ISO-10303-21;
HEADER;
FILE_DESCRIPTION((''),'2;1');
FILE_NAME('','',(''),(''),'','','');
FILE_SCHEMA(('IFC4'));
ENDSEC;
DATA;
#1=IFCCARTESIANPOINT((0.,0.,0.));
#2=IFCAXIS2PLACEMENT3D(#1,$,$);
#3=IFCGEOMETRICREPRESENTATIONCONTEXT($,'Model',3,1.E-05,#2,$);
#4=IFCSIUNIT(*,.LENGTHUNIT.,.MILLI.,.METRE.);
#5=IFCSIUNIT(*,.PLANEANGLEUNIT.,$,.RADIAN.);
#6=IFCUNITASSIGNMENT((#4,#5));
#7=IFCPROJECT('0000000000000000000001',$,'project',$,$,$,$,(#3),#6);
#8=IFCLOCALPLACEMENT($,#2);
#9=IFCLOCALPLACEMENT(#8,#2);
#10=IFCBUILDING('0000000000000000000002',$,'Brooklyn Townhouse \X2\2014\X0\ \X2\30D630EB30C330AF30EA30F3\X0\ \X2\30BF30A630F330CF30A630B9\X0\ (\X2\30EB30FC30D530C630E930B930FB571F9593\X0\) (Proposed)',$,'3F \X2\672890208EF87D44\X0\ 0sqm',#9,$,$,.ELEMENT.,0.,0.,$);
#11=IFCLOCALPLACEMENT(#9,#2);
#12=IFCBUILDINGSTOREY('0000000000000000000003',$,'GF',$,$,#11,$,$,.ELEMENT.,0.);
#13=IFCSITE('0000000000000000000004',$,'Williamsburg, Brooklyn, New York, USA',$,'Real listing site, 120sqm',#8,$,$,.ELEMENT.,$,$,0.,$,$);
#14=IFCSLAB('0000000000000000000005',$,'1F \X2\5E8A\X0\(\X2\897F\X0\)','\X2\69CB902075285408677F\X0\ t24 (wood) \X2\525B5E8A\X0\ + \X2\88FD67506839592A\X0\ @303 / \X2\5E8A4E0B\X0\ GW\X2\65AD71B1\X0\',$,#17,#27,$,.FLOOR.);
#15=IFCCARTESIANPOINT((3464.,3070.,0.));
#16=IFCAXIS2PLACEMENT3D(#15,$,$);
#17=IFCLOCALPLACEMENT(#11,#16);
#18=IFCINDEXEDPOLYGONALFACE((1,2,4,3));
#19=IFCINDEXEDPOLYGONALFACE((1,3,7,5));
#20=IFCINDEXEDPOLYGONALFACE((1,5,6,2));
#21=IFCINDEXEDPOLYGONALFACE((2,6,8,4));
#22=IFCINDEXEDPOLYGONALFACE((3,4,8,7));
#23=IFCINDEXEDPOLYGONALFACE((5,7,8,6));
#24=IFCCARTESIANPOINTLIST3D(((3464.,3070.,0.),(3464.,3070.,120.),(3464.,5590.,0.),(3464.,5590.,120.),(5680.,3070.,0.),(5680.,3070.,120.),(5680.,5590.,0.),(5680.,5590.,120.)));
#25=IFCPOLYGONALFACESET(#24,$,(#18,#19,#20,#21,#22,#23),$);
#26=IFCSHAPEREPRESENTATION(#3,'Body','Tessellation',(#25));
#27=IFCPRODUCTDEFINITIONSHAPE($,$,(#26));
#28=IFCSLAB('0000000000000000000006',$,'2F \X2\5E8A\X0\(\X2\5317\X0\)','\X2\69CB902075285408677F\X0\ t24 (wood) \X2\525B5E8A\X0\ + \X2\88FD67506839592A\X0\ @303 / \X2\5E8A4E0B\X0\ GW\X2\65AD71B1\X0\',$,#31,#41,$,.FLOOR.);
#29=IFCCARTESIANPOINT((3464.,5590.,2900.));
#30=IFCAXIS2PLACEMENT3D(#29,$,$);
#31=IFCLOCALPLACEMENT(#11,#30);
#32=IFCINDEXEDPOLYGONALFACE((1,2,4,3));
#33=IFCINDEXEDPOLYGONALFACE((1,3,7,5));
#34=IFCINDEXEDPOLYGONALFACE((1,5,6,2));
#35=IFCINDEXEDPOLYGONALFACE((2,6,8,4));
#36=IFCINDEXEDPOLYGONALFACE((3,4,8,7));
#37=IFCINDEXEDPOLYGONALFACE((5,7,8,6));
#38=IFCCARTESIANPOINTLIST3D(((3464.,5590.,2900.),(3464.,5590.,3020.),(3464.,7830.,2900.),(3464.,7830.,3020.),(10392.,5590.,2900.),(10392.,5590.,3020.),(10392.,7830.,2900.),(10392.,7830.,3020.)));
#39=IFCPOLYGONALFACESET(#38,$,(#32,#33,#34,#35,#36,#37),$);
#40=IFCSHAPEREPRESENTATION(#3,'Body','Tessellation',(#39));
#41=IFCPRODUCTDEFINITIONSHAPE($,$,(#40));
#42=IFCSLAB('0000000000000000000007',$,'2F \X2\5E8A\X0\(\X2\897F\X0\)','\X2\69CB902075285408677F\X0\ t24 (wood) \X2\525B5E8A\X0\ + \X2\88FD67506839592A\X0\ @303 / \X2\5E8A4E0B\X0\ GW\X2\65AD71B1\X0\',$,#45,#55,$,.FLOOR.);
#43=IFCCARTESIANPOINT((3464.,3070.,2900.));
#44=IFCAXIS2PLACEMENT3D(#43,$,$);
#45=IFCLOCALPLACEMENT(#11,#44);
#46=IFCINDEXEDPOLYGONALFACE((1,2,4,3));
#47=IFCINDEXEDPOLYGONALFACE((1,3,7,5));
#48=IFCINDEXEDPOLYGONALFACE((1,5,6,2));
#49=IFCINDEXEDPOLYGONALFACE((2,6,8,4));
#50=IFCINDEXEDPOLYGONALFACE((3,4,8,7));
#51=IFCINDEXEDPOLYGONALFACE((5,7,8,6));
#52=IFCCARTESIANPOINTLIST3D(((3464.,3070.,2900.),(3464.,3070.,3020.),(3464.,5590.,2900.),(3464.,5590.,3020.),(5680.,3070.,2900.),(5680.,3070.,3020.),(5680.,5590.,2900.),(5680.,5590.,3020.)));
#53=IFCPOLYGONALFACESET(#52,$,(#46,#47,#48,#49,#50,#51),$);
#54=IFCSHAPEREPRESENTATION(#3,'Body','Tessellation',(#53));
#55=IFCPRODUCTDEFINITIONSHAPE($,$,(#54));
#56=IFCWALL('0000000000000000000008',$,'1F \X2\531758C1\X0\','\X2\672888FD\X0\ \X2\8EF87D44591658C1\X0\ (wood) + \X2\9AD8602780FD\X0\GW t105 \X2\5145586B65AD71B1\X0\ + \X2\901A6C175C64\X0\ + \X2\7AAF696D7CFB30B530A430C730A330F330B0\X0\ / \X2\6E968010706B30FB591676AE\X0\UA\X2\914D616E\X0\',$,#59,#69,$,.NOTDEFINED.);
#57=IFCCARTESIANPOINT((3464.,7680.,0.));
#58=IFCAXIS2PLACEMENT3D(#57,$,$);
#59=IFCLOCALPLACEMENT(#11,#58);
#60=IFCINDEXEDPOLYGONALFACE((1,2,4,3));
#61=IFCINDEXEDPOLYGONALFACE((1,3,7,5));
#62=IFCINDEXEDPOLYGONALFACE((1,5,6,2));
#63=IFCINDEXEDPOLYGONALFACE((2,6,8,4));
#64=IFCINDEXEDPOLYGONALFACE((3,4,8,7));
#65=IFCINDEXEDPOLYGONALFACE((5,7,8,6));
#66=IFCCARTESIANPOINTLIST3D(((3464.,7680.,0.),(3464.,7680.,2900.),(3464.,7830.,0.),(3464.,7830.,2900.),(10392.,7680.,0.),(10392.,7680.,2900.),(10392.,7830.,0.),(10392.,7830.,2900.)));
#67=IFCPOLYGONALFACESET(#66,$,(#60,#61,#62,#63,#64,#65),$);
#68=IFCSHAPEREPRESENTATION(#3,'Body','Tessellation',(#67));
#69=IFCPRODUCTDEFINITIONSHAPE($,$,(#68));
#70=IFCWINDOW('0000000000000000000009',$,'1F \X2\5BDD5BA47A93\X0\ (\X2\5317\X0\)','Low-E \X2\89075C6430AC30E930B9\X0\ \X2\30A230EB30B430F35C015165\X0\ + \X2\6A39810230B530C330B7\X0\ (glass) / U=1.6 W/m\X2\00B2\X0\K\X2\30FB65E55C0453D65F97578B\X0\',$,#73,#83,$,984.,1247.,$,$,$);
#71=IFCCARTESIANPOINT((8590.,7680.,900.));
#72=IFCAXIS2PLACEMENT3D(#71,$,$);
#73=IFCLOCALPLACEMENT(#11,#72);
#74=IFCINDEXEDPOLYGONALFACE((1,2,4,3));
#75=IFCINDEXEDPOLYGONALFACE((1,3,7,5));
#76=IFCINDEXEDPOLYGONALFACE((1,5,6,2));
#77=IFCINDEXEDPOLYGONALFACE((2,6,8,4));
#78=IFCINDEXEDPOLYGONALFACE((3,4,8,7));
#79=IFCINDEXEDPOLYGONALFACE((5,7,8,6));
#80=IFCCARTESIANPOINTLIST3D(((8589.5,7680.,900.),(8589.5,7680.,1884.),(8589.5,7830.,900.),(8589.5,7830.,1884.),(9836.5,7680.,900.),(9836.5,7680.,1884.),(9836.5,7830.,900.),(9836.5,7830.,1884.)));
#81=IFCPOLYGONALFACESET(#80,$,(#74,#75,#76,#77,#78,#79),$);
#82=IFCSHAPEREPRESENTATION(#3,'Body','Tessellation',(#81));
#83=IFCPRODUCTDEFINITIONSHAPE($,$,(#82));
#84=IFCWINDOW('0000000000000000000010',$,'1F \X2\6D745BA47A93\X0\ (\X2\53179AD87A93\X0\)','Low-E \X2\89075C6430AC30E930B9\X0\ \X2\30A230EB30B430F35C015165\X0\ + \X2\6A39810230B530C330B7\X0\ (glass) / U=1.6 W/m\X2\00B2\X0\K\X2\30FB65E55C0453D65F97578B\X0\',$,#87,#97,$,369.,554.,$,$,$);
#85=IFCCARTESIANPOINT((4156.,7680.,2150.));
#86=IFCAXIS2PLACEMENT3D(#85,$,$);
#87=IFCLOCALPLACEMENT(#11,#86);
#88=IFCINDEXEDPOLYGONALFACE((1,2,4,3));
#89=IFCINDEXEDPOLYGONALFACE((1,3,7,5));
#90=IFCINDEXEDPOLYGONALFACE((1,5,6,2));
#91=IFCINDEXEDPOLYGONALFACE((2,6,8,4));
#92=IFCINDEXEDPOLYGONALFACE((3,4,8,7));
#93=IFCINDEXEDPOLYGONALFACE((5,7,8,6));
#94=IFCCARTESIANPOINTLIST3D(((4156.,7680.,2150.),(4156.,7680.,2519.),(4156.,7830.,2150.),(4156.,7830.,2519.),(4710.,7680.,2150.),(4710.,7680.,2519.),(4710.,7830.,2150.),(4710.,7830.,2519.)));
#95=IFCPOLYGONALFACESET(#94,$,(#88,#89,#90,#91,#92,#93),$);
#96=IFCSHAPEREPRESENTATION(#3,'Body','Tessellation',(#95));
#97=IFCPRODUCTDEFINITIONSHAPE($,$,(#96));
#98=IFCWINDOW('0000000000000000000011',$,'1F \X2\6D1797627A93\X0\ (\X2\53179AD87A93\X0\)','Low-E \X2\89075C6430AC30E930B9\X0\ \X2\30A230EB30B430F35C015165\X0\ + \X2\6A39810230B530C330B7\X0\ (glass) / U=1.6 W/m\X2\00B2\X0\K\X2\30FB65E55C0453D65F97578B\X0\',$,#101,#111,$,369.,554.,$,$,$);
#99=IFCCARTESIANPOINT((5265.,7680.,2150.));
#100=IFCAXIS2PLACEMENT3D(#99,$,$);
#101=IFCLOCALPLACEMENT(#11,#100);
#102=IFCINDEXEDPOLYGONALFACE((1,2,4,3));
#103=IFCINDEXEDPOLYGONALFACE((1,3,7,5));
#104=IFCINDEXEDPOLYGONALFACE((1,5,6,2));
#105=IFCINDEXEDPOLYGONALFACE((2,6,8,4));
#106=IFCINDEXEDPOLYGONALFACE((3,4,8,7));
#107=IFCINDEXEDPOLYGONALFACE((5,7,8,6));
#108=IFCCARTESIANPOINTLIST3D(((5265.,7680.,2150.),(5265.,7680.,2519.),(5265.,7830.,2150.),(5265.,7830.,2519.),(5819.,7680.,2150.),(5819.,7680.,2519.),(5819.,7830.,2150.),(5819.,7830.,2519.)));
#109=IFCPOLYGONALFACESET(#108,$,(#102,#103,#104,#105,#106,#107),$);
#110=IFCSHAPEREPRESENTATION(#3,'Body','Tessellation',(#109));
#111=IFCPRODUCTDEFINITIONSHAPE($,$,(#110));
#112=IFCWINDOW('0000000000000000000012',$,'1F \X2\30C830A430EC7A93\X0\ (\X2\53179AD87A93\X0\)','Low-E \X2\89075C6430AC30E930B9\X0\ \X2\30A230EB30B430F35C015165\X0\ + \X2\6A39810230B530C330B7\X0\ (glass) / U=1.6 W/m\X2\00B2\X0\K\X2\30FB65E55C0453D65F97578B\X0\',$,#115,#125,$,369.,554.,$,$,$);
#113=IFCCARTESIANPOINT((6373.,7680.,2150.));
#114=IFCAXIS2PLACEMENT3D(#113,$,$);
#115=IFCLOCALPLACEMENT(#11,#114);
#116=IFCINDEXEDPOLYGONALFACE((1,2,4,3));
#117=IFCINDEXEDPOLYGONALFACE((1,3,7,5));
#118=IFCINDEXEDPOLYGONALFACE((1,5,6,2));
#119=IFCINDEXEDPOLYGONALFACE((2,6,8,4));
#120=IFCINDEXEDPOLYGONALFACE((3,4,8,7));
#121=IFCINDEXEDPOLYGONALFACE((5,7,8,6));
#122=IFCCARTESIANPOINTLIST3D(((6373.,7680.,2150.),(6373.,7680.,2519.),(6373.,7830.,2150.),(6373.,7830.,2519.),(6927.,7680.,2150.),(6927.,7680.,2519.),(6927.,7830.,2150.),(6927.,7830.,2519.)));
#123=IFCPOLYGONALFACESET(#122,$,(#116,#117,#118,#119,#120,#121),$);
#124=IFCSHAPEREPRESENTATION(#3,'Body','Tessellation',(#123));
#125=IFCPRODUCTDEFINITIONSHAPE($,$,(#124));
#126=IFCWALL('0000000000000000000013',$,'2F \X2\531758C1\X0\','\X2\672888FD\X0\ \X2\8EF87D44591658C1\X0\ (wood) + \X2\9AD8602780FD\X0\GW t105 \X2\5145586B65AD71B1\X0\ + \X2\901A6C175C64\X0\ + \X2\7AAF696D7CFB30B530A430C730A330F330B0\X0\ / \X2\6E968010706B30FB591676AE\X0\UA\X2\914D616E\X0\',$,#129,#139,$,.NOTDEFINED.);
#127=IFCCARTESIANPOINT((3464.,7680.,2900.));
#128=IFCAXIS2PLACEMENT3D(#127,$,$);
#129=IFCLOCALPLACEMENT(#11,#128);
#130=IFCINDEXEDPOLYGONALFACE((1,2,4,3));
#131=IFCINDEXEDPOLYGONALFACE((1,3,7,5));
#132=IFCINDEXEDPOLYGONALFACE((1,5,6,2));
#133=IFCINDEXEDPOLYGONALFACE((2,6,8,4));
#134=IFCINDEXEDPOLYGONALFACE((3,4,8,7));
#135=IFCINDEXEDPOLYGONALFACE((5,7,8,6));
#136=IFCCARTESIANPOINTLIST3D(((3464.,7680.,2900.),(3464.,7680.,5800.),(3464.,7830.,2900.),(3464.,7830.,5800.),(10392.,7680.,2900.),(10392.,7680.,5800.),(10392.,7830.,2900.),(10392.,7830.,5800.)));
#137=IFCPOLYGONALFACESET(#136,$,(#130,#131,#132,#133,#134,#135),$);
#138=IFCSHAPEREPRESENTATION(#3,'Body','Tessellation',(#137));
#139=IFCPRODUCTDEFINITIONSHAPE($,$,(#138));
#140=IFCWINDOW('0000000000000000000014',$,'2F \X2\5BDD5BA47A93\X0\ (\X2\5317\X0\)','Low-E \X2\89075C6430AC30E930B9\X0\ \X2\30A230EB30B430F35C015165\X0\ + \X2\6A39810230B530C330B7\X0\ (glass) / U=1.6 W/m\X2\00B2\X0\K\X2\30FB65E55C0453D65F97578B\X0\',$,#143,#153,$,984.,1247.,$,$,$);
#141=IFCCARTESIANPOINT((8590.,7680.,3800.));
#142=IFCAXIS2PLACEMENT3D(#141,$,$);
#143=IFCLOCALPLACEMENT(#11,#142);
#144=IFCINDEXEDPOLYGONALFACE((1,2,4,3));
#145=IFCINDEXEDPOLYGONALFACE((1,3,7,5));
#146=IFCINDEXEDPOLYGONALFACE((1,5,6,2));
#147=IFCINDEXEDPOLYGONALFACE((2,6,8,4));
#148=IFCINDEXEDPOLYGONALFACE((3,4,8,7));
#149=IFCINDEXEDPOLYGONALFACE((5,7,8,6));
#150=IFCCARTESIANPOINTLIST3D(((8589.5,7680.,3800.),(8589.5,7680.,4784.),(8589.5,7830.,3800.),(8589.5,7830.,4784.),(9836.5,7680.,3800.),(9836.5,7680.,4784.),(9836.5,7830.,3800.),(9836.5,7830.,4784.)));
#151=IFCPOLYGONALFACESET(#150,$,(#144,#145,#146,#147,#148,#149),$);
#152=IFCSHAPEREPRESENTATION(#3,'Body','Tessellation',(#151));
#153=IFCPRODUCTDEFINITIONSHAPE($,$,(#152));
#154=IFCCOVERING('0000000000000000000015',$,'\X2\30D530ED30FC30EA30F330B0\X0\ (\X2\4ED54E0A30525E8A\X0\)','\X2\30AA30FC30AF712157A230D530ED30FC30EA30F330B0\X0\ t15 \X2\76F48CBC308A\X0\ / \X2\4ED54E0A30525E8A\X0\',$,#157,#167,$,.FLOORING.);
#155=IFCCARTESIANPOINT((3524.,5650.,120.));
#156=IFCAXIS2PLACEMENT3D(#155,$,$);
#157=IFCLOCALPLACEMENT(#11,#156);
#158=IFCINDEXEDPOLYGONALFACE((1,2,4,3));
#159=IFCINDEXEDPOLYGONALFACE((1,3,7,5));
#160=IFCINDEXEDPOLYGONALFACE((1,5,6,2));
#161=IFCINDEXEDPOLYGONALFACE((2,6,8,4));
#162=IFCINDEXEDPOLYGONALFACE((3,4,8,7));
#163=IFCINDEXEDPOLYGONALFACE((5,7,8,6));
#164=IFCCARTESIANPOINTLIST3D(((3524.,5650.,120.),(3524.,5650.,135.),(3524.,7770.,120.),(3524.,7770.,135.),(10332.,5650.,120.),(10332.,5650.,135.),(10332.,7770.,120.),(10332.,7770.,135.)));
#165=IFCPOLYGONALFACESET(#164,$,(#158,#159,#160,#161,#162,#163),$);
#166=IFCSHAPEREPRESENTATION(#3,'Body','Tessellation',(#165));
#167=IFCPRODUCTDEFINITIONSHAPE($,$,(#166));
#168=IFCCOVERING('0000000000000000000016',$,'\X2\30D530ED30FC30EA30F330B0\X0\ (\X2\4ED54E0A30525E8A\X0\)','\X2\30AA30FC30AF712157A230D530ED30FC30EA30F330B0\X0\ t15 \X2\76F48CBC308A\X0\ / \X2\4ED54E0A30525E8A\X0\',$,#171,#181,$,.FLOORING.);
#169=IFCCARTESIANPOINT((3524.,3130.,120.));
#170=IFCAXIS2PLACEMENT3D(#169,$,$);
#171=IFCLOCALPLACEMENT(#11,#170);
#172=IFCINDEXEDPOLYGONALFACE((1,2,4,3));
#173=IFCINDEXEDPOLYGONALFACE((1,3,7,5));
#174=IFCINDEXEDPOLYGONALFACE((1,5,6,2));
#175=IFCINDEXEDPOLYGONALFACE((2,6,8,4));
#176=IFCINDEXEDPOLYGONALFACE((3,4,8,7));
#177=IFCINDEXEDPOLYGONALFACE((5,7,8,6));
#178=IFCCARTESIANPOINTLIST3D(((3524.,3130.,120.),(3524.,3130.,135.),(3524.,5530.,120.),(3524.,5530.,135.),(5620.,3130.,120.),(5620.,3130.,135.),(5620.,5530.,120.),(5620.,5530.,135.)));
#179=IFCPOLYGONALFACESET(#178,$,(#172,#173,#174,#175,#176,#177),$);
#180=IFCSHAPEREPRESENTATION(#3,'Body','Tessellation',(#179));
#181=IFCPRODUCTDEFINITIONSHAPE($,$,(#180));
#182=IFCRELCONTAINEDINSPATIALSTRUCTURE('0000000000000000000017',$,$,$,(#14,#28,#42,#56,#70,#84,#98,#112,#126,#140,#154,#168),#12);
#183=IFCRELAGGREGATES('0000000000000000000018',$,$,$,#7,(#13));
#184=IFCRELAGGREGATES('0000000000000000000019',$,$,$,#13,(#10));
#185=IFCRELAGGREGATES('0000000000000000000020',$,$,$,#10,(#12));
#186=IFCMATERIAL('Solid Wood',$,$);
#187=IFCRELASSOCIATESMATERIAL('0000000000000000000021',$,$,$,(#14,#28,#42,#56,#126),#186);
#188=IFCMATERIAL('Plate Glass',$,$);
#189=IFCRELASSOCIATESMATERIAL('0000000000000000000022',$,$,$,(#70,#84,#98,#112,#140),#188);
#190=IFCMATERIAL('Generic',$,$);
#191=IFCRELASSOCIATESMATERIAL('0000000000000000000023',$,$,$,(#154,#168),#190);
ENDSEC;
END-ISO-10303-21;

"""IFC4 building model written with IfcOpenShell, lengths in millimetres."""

from ifc_helpers import new_model, si_unit, frame, frame_2d, origin, place, context, project, spatial, rectangle, extrude, material, element, fill, save


model = new_model("IFC4")

# Units and contexts
model_context = context("Model", 3, precision=1e-05, world=origin())
ifc_project = project(units=[si_unit("LENGTHUNIT", "METRE", prefix="MILLI"), si_unit("PLANEANGLEUNIT", "RADIAN")], contexts=[model_context])

# Site, building, storey
site_placement = place(None, origin())
site = spatial("IfcSite", under=ifc_project, at=site_placement, Name="Williamsburg, Brooklyn, New York, USA", ObjectType="Real listing site, 120sqm", CompositionType="ELEMENT", RefElevation=0.0)
building_placement = place(site_placement, origin())
building = spatial("IfcBuilding", under=site, at=building_placement, Name="Brooklyn Townhouse — ブルックリン タウンハウス (ルーフテラス・土間) (Proposed)", ObjectType="3F 木造軸組 0sqm", CompositionType="ELEMENT", ElevationOfRefHeight=0.0, ElevationOfTerrain=0.0)
storey_placement = place(building_placement, origin())
storey = spatial("IfcBuildingStorey", under=building, at=storey_placement, Name="GF", CompositionType="ELEMENT", Elevation=0.0)

# Slabs
ifc_material_1 = material(Name="Solid Wood")
slab_1_placement = place(storey_placement, frame((3464.0, 3070.0, 0.0)))
element("IfcSlab", 1, at=slab_1_placement, inside=storey, material=ifc_material_1, Name="1F 床(西)", Description="構造用合板 t24 (wood) 剛床 + 製材根太 @303 / 床下 GW断熱", PredefinedType="FLOOR", context=model_context, shape_type="SweptSolid", body=[
    extrude(rectangle(XDim=2216.0, YDim=2520.0, at=frame_2d((1108.0, 1260.0))), frame((3464.0, 3070.0, 0.0)), (0.0, 0.0, 1.0), 120.0),
])
slab_2_placement = place(storey_placement, frame((3464.0, 5590.0, 2900.0)))
element("IfcSlab", 2, at=slab_2_placement, inside=storey, material=ifc_material_1, Name="2F 床(北)", Description="構造用合板 t24 (wood) 剛床 + 製材根太 @303 / 床下 GW断熱", PredefinedType="FLOOR", context=model_context, shape_type="SweptSolid", body=[
    extrude(rectangle(XDim=6928.0, YDim=2240.0, at=frame_2d((3464.0, 1120.0))), frame((3464.0, 5590.0, 2900.0)), (0.0, 0.0, 1.0), 120.0),
])
slab_3_placement = place(storey_placement, frame((3464.0, 3070.0, 2900.0)))
element("IfcSlab", 3, at=slab_3_placement, inside=storey, material=ifc_material_1, Name="2F 床(西)", Description="構造用合板 t24 (wood) 剛床 + 製材根太 @303 / 床下 GW断熱", PredefinedType="FLOOR", context=model_context, shape_type="SweptSolid", body=[
    extrude(rectangle(XDim=2216.0, YDim=2520.0, at=frame_2d((1108.0, 1260.0))), frame((3464.0, 3070.0, 2900.0)), (0.0, 0.0, 1.0), 120.0),
])

# Wall, openings, windows
wall_1_placement = place(storey_placement, frame((3464.0, 7680.0, 0.0)))
wall_1 = element("IfcWall", 4, at=wall_1_placement, inside=storey, material=ifc_material_1, Name="1F 北壁", Description="木製 軸組外壁 (wood) + 高性能GW t105 充填断熱 + 通気層 + 窯業系サイディング / 準耐火・外皮UA配慮", PredefinedType="NOTDEFINED", context=model_context, shape_type="SweptSolid", body=[
    extrude(rectangle(XDim=6928.0, YDim=150.0, at=frame_2d((3464.0, 75.0))), frame((3464.0, 7680.0, 0.0)), (0.0, 0.0, 1.0), 2900.0),
])
opening_1_placement = place(storey_placement, frame((8590.0, 7680.0, 900.0)))
opening_1 = element("IfcOpeningElement", 5, at=opening_1_placement, cuts=wall_1, PredefinedType="NOTDEFINED", context=model_context, shape_type="SweptSolid", body=[
    extrude(rectangle(XDim=1247.0, YDim=150.0, at=frame_2d((623.0, 75.0))), frame((8590.0, 7680.0, 900.0)), (0.0, 0.0, 1.0), 984.0),
])
opening_2_placement = place(storey_placement, frame((4156.0, 7680.0, 2150.0)))
opening_2 = element("IfcOpeningElement", 6, at=opening_2_placement, cuts=wall_1, PredefinedType="NOTDEFINED", context=model_context, shape_type="SweptSolid", body=[
    extrude(rectangle(XDim=554.0, YDim=150.0, at=frame_2d((277.0, 75.0))), frame((4156.0, 7680.0, 2150.0)), (0.0, 0.0, 1.0), 369.0),
])
opening_3_placement = place(storey_placement, frame((5265.0, 7680.0, 2150.0)))
opening_3 = element("IfcOpeningElement", 7, at=opening_3_placement, cuts=wall_1, PredefinedType="NOTDEFINED", context=model_context, shape_type="SweptSolid", body=[
    extrude(rectangle(XDim=554.0, YDim=150.0, at=frame_2d((277.0, 75.0))), frame((5265.0, 7680.0, 2150.0)), (0.0, 0.0, 1.0), 369.0),
])
opening_4_placement = place(storey_placement, frame((6373.0, 7680.0, 2150.0)))
opening_4 = element("IfcOpeningElement", 8, at=opening_4_placement, cuts=wall_1, PredefinedType="NOTDEFINED", context=model_context, shape_type="SweptSolid", body=[
    extrude(rectangle(XDim=554.0, YDim=150.0, at=frame_2d((277.0, 75.0))), frame((6373.0, 7680.0, 2150.0)), (0.0, 0.0, 1.0), 369.0),
])
ifc_material_2 = material(Name="Plate Glass")
window_1_placement = place(storey_placement, frame((8590.0, 7680.0, 900.0)))
window_1 = element("IfcWindow", 9, at=window_1_placement, inside=storey, material=ifc_material_2, Name="1F 寝室窓 (北)", Description="Low-E 複層ガラス アルゴン封入 + 樹脂サッシ (glass) / U=1.6 W/m²K・日射取得型", OverallHeight=984.0, OverallWidth=1247.0, context=model_context, shape_type="SweptSolid", body=[
    extrude(rectangle(XDim=1247.0, YDim=150.0, at=frame_2d((623.0, 75.0))), frame((8590.0, 7680.0, 900.0)), (0.0, 0.0, 1.0), 984.0),
])
fill(opening_1, window_1)
window_2_placement = place(storey_placement, frame((4156.0, 7680.0, 2150.0)))
window_2 = element("IfcWindow", 10, at=window_2_placement, inside=storey, material=ifc_material_2, Name="1F 浴室窓 (北高窓)", Description="Low-E 複層ガラス アルゴン封入 + 樹脂サッシ (glass) / U=1.6 W/m²K・日射取得型", OverallHeight=369.0, OverallWidth=554.0, context=model_context, shape_type="SweptSolid", body=[
    extrude(rectangle(XDim=554.0, YDim=150.0, at=frame_2d((277.0, 75.0))), frame((4156.0, 7680.0, 2150.0)), (0.0, 0.0, 1.0), 369.0),
])
fill(opening_2, window_2)
window_3_placement = place(storey_placement, frame((5265.0, 7680.0, 2150.0)))
window_3 = element("IfcWindow", 11, at=window_3_placement, inside=storey, material=ifc_material_2, Name="1F 洗面窓 (北高窓)", Description="Low-E 複層ガラス アルゴン封入 + 樹脂サッシ (glass) / U=1.6 W/m²K・日射取得型", OverallHeight=369.0, OverallWidth=554.0, context=model_context, shape_type="SweptSolid", body=[
    extrude(rectangle(XDim=554.0, YDim=150.0, at=frame_2d((277.0, 75.0))), frame((5265.0, 7680.0, 2150.0)), (0.0, 0.0, 1.0), 369.0),
])
fill(opening_3, window_3)
window_4_placement = place(storey_placement, frame((6373.0, 7680.0, 2150.0)))
window_4 = element("IfcWindow", 12, at=window_4_placement, inside=storey, material=ifc_material_2, Name="1F トイレ窓 (北高窓)", Description="Low-E 複層ガラス アルゴン封入 + 樹脂サッシ (glass) / U=1.6 W/m²K・日射取得型", OverallHeight=369.0, OverallWidth=554.0, context=model_context, shape_type="SweptSolid", body=[
    extrude(rectangle(XDim=554.0, YDim=150.0, at=frame_2d((277.0, 75.0))), frame((6373.0, 7680.0, 2150.0)), (0.0, 0.0, 1.0), 369.0),
])
fill(opening_4, window_4)

# Wall, opening, window
wall_2_placement = place(storey_placement, frame((3464.0, 7680.0, 2900.0)))
wall_2 = element("IfcWall", 13, at=wall_2_placement, inside=storey, material=ifc_material_1, Name="2F 北壁", Description="木製 軸組外壁 (wood) + 高性能GW t105 充填断熱 + 通気層 + 窯業系サイディング / 準耐火・外皮UA配慮", PredefinedType="NOTDEFINED", context=model_context, shape_type="SweptSolid", body=[
    extrude(rectangle(XDim=6928.0, YDim=150.0, at=frame_2d((3464.0, 75.0))), frame((3464.0, 7680.0, 2900.0)), (0.0, 0.0, 1.0), 2900.0),
])
opening_5_placement = place(storey_placement, frame((8590.0, 7680.0, 3800.0)))
opening_5 = element("IfcOpeningElement", 14, at=opening_5_placement, cuts=wall_2, PredefinedType="NOTDEFINED", context=model_context, shape_type="SweptSolid", body=[
    extrude(rectangle(XDim=1247.0, YDim=150.0, at=frame_2d((623.0, 75.0))), frame((8590.0, 7680.0, 3800.0)), (0.0, 0.0, 1.0), 984.0),
])
window_5_placement = place(storey_placement, frame((8590.0, 7680.0, 3800.0)))
window_5 = element("IfcWindow", 15, at=window_5_placement, inside=storey, material=ifc_material_2, Name="2F 寝室窓 (北)", Description="Low-E 複層ガラス アルゴン封入 + 樹脂サッシ (glass) / U=1.6 W/m²K・日射取得型", OverallHeight=984.0, OverallWidth=1247.0, context=model_context, shape_type="SweptSolid", body=[
    extrude(rectangle(XDim=1247.0, YDim=150.0, at=frame_2d((623.0, 75.0))), frame((8590.0, 7680.0, 3800.0)), (0.0, 0.0, 1.0), 984.0),
])
fill(opening_5, window_5)

# Coverings
ifc_material_3 = material(Name="Generic")
covering_1_placement = place(storey_placement, frame((3524.0, 5650.0, 120.0)))
element("IfcCovering", 16, at=covering_1_placement, inside=storey, material=ifc_material_3, Name="フローリング (仕上げ床)", Description="オーク無垢フローリング t15 直貼り / 仕上げ床", PredefinedType="FLOORING", context=model_context, shape_type="SweptSolid", body=[
    extrude(rectangle(XDim=6808.0, YDim=2120.0, at=frame_2d((3404.0, 1060.0))), frame((3524.0, 5650.0, 120.0)), (0.0, 0.0, 1.0), 15.0),
])
covering_2_placement = place(storey_placement, frame((3524.0, 3130.0, 120.0)))
element("IfcCovering", 17, at=covering_2_placement, inside=storey, material=ifc_material_3, Name="フローリング (仕上げ床)", Description="オーク無垢フローリング t15 直貼り / 仕上げ床", PredefinedType="FLOORING", context=model_context, shape_type="SweptSolid", body=[
    extrude(rectangle(XDim=2096.0, YDim=2400.0, at=frame_2d((1048.0, 1200.0))), frame((3524.0, 3130.0, 120.0)), (0.0, 0.0, 1.0), 15.0),
])

save(model, "model.ifc")
